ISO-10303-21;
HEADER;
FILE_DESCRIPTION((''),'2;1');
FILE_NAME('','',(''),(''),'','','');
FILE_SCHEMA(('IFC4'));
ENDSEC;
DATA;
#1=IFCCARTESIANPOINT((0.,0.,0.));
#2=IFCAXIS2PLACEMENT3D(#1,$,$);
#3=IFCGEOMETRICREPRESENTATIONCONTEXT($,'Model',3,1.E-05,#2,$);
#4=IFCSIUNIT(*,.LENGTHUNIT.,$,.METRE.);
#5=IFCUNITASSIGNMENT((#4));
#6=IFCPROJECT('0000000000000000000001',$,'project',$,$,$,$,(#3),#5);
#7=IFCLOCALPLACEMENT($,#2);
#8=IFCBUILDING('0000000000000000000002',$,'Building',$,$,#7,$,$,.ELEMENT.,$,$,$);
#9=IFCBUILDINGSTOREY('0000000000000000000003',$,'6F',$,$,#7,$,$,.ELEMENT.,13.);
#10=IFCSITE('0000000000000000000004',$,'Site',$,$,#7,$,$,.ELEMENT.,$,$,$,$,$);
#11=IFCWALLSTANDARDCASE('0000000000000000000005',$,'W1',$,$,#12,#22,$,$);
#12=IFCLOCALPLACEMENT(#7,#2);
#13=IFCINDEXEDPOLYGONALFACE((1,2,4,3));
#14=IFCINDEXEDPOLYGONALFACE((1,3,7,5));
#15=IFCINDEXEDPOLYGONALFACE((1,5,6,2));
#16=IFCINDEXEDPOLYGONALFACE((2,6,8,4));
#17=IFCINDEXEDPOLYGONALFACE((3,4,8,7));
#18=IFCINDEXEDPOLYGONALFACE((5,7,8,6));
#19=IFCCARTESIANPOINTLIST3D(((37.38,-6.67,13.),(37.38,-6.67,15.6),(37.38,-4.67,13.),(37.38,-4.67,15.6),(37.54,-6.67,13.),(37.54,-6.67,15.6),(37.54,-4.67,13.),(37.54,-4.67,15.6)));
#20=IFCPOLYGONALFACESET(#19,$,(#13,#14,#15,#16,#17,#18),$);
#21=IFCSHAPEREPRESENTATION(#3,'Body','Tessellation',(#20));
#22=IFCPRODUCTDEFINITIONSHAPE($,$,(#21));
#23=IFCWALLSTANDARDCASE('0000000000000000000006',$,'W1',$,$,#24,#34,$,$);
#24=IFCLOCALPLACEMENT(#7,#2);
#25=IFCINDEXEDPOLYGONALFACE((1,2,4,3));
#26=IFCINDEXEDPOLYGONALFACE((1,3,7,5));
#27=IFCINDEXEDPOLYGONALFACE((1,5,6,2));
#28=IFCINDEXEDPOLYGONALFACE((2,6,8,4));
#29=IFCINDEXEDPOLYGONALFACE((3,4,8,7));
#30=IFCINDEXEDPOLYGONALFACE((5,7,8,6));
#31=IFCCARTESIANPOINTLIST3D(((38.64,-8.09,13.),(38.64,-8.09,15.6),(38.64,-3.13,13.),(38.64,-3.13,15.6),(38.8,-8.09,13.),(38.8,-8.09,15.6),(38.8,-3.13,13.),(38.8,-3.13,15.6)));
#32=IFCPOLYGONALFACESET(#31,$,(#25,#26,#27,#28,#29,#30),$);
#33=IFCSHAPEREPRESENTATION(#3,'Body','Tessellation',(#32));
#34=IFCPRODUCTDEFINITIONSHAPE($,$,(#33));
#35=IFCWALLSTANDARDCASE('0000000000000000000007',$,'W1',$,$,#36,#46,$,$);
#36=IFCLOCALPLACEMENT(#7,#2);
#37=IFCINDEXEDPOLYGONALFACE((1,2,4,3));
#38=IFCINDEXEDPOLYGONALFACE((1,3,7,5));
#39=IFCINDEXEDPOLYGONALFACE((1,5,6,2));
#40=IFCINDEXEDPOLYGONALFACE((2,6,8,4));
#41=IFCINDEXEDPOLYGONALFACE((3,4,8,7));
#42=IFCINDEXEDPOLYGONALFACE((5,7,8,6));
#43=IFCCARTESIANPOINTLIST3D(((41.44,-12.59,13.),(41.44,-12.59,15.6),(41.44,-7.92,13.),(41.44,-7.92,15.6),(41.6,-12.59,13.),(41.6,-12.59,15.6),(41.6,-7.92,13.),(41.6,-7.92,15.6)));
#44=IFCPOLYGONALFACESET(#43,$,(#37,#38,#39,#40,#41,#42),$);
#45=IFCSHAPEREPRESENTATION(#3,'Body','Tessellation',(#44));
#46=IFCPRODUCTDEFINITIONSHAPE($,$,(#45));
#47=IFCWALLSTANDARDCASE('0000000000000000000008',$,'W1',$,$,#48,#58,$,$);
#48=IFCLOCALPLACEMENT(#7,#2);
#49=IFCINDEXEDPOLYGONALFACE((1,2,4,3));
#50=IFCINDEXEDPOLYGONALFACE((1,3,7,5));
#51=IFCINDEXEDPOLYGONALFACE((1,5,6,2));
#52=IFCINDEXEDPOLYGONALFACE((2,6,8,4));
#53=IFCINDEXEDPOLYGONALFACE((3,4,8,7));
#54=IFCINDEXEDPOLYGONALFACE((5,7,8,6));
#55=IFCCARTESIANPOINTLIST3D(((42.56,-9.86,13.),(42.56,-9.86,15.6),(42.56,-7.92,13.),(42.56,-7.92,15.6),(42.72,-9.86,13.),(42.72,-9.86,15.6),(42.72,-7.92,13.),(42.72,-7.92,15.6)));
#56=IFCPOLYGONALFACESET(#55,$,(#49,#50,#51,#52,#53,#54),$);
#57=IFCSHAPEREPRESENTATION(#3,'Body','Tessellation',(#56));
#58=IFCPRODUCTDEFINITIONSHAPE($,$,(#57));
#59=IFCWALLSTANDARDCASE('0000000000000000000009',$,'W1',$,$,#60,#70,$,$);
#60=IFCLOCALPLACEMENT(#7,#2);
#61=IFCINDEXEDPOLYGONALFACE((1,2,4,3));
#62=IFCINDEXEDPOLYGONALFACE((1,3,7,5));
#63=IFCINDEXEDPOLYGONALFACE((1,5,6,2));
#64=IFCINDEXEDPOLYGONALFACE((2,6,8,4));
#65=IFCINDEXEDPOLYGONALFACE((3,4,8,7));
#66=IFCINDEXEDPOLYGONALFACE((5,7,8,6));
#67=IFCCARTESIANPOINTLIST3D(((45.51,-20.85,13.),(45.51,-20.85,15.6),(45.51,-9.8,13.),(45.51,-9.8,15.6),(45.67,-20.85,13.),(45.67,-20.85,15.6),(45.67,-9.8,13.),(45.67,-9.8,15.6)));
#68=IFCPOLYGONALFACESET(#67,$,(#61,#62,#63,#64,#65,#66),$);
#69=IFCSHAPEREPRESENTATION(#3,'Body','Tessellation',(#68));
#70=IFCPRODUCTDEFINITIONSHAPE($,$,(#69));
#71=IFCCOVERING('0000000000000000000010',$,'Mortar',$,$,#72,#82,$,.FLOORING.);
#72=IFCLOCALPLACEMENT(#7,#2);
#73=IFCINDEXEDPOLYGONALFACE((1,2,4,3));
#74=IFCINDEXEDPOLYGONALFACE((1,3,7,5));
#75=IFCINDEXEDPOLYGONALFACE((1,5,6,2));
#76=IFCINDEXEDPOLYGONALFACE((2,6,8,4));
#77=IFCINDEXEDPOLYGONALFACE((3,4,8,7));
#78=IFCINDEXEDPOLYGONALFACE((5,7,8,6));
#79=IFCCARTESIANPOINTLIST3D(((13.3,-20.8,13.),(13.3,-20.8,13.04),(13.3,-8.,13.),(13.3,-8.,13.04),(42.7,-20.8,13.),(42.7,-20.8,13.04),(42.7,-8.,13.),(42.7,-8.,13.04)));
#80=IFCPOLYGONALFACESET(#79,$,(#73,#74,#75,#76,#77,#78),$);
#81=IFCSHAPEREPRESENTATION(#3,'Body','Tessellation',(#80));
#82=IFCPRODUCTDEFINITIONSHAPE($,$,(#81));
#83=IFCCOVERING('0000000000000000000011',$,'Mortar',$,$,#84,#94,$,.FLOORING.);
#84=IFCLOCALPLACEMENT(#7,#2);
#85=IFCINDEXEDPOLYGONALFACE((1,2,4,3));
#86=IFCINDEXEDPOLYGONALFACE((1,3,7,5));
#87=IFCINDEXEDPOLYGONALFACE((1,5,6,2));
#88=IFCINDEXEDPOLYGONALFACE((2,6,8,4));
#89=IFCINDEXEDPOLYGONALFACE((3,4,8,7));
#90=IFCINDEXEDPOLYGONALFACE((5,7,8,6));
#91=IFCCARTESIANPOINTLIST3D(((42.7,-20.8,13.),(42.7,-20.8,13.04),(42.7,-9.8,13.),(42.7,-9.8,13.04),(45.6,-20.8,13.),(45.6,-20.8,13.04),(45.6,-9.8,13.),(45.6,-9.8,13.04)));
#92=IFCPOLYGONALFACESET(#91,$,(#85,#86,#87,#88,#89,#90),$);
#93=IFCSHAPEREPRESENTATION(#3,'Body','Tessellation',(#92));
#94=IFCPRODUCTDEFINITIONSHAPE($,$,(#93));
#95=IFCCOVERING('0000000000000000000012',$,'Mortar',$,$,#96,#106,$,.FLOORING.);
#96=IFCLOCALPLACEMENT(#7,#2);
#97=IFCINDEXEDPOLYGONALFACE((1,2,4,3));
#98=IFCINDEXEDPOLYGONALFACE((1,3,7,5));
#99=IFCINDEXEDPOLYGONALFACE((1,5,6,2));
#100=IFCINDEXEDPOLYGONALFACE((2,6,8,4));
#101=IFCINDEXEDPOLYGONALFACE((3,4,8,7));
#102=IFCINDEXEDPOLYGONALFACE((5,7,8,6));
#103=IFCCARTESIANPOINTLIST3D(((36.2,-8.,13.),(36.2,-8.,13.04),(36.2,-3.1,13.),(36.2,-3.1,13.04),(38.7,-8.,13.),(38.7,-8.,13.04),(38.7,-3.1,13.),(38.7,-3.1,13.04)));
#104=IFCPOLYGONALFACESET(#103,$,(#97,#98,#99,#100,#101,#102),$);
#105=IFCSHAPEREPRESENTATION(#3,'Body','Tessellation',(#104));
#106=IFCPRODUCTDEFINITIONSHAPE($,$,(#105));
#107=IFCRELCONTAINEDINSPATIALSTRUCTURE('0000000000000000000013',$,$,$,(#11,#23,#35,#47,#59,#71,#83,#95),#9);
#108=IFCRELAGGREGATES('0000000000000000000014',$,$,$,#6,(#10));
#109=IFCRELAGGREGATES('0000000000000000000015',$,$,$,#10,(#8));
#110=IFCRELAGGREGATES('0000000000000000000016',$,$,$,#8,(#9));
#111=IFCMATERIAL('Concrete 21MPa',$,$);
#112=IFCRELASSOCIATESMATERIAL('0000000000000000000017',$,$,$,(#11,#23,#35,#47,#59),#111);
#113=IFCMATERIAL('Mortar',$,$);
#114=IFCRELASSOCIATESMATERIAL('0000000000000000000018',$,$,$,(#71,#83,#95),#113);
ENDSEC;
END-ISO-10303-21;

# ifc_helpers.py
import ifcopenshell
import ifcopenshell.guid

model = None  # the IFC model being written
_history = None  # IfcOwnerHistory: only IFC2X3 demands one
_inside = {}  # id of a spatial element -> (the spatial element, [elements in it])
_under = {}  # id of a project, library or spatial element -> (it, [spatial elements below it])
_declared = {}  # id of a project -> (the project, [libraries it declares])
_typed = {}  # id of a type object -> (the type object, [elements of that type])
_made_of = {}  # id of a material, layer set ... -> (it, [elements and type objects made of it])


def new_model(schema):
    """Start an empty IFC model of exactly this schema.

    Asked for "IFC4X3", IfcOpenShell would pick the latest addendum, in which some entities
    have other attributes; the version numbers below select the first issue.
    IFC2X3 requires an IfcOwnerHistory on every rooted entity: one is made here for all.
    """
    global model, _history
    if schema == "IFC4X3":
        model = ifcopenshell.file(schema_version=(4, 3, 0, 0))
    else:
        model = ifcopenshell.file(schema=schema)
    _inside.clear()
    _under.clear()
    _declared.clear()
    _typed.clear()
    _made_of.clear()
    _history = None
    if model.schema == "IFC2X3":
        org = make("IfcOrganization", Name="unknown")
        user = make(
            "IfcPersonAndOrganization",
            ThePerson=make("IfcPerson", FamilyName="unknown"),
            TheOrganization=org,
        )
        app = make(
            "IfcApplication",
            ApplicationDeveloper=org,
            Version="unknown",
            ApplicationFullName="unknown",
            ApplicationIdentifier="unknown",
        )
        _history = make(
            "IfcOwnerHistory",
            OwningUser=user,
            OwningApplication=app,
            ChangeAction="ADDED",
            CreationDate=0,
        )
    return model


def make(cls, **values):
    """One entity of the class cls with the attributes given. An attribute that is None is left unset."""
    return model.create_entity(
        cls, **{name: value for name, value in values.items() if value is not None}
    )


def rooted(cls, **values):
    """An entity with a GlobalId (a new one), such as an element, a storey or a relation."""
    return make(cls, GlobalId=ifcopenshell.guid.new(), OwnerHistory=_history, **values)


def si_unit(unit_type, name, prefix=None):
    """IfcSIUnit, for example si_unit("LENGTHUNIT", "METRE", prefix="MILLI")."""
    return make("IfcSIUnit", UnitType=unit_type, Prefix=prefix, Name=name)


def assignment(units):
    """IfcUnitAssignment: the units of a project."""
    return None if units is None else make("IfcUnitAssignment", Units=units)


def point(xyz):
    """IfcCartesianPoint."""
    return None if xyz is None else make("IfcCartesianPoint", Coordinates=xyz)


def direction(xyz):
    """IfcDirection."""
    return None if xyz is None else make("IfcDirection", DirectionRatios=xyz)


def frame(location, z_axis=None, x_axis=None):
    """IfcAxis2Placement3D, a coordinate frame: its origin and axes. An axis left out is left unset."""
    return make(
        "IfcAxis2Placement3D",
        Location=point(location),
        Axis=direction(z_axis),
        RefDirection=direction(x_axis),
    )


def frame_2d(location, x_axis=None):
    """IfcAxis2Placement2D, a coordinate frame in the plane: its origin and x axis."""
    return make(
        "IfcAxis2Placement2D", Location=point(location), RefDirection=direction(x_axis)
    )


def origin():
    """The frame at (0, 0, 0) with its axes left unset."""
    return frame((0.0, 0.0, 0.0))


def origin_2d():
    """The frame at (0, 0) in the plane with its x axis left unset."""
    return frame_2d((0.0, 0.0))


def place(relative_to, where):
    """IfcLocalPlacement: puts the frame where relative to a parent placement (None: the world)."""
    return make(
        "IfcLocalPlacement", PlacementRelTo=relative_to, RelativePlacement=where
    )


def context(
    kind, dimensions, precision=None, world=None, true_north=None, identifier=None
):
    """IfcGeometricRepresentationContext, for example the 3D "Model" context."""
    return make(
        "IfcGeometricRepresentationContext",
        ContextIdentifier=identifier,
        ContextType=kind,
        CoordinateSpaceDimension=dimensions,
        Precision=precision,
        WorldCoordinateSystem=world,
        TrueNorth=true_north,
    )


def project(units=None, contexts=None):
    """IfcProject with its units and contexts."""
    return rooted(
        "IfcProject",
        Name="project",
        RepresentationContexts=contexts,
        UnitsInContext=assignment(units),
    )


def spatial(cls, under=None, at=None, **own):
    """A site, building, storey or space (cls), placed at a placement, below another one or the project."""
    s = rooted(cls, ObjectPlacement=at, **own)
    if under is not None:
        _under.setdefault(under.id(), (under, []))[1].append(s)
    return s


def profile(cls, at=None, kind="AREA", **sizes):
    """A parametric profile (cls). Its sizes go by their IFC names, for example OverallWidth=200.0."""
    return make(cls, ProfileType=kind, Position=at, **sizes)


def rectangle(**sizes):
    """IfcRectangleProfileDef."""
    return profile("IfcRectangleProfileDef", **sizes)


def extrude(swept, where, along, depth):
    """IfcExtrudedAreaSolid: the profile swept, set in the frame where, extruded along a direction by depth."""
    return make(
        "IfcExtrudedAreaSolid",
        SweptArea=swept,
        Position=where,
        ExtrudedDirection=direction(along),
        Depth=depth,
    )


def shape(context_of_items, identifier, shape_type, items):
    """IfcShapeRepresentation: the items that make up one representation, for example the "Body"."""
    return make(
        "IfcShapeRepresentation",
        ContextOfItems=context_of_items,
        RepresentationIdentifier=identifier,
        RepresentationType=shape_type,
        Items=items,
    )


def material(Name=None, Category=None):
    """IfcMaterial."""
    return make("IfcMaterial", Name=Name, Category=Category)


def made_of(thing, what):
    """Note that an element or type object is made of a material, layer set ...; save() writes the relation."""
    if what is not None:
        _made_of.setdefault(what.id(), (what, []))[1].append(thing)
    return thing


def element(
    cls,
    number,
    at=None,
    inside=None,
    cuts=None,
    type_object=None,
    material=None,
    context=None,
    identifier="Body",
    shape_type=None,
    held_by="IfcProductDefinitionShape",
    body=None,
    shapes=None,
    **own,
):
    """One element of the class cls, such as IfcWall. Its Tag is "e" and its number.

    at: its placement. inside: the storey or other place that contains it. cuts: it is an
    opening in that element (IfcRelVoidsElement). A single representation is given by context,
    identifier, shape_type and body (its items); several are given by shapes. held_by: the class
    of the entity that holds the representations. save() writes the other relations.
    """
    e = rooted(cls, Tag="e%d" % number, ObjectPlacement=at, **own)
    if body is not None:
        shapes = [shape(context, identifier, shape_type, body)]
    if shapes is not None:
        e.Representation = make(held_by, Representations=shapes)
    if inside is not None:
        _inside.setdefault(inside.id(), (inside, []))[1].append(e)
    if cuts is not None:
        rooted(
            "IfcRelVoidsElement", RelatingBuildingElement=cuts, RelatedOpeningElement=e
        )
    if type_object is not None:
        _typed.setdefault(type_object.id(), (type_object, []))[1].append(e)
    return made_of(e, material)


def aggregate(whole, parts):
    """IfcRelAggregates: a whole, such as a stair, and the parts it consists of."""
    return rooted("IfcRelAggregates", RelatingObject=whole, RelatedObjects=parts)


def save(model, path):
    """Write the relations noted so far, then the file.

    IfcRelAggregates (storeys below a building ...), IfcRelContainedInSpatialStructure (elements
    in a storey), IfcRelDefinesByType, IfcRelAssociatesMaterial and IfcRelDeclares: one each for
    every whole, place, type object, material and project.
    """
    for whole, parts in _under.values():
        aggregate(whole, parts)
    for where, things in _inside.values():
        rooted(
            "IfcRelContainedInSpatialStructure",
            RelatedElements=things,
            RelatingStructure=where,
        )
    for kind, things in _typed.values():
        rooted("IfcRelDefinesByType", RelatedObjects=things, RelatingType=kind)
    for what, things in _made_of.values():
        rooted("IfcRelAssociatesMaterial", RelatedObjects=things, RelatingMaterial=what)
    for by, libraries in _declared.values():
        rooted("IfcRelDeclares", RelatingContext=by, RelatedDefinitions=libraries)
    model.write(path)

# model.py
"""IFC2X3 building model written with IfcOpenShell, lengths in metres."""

from ifc_helpers import new_model, si_unit, frame, origin, origin_2d, place, context, project, spatial, rectangle, extrude, material, element, save


model = new_model("IFC2X3")

# Units and contexts
model_context = context("Model", 3, precision=1e-05, world=origin())
ifc_project = project(units=[si_unit("LENGTHUNIT", "METRE")], contexts=[model_context])

# Site, building, storey
placement = place(None, origin())
site = spatial("IfcSite", under=ifc_project, at=placement, Name="Site", CompositionType="ELEMENT")
building = spatial("IfcBuilding", under=site, at=placement, Name="Building", CompositionType="ELEMENT")
storey = spatial("IfcBuildingStorey", under=building, at=placement, Name="6F", CompositionType="ELEMENT", Elevation=13.0)

# Shared definitions
ifc_material_1 = material(Name="Concrete 21MPa")

# Walls
wall_1_placement = place(None, frame((37.46, -5.67, 13.0)))
element("IfcWallStandardCase", 1, at=wall_1_placement, inside=storey, material=ifc_material_1, Name="W1", context=model_context, shape_type="SweptSolid", body=[
    extrude(rectangle(XDim=0.16, YDim=2.0, at=origin_2d()), origin(), (0.0, 0.0, 1.0), 2.6),
])
wall_2_placement = place(None, frame((38.72, -5.61, 13.0)))
element("IfcWallStandardCase", 2, at=wall_2_placement, inside=storey, material=ifc_material_1, Name="W1", context=model_context, shape_type="SweptSolid", body=[
    extrude(rectangle(XDim=0.16, YDim=4.96, at=origin_2d()), origin(), (0.0, 0.0, 1.0), 2.6),
])
wall_3_placement = place(None, frame((41.52, -10.255, 13.0)))
element("IfcWallStandardCase", 3, at=wall_3_placement, inside=storey, material=ifc_material_1, Name="W1", context=model_context, shape_type="SweptSolid", body=[
    extrude(rectangle(XDim=0.16, YDim=4.67, at=origin_2d()), origin(), (0.0, 0.0, 1.0), 2.6),
])
wall_4_placement = place(None, frame((42.64, -8.89, 13.0)))
element("IfcWallStandardCase", 4, at=wall_4_placement, inside=storey, material=ifc_material_1, Name="W1", context=model_context, shape_type="SweptSolid", body=[
    extrude(rectangle(XDim=0.16, YDim=1.94, at=origin_2d()), origin(), (0.0, 0.0, 1.0), 2.6),
])
wall_5_placement = place(None, frame((45.59, -15.325, 13.0)))
element("IfcWallStandardCase", 5, at=wall_5_placement, inside=storey, material=ifc_material_1, Name="W1", context=model_context, shape_type="SweptSolid", body=[
    extrude(rectangle(XDim=0.16, YDim=11.05, at=origin_2d()), origin(), (0.0, 0.0, 1.0), 2.6),
])

# Coverings
ifc_material_2 = material(Name="Mortar")
covering_1_placement = place(None, frame((28.0, -14.4, 13.0)))
element("IfcCovering", 6, at=covering_1_placement, inside=storey, material=ifc_material_2, Name="Mortar", PredefinedType="FLOORING", context=model_context, shape_type="SweptSolid", body=[
    extrude(rectangle(XDim=29.4, YDim=12.8, at=origin_2d()), origin(), (0.0, 0.0, 1.0), 0.04),
])
covering_2_placement = place(None, frame((44.15, -15.3, 13.0)))
element("IfcCovering", 7, at=covering_2_placement, inside=storey, material=ifc_material_2, Name="Mortar", PredefinedType="FLOORING", context=model_context, shape_type="SweptSolid", body=[
    extrude(rectangle(XDim=2.9, YDim=11.0, at=origin_2d()), origin(), (0.0, 0.0, 1.0), 0.04),
])
covering_3_placement = place(None, frame((37.45, -5.55, 13.0)))
element("IfcCovering", 8, at=covering_3_placement, inside=storey, material=ifc_material_2, Name="Mortar", PredefinedType="FLOORING", context=model_context, shape_type="SweptSolid", body=[
    extrude(rectangle(XDim=2.5, YDim=4.9, at=origin_2d()), origin(), (0.0, 0.0, 1.0), 0.04),
])

save(model, "model.ifc")
